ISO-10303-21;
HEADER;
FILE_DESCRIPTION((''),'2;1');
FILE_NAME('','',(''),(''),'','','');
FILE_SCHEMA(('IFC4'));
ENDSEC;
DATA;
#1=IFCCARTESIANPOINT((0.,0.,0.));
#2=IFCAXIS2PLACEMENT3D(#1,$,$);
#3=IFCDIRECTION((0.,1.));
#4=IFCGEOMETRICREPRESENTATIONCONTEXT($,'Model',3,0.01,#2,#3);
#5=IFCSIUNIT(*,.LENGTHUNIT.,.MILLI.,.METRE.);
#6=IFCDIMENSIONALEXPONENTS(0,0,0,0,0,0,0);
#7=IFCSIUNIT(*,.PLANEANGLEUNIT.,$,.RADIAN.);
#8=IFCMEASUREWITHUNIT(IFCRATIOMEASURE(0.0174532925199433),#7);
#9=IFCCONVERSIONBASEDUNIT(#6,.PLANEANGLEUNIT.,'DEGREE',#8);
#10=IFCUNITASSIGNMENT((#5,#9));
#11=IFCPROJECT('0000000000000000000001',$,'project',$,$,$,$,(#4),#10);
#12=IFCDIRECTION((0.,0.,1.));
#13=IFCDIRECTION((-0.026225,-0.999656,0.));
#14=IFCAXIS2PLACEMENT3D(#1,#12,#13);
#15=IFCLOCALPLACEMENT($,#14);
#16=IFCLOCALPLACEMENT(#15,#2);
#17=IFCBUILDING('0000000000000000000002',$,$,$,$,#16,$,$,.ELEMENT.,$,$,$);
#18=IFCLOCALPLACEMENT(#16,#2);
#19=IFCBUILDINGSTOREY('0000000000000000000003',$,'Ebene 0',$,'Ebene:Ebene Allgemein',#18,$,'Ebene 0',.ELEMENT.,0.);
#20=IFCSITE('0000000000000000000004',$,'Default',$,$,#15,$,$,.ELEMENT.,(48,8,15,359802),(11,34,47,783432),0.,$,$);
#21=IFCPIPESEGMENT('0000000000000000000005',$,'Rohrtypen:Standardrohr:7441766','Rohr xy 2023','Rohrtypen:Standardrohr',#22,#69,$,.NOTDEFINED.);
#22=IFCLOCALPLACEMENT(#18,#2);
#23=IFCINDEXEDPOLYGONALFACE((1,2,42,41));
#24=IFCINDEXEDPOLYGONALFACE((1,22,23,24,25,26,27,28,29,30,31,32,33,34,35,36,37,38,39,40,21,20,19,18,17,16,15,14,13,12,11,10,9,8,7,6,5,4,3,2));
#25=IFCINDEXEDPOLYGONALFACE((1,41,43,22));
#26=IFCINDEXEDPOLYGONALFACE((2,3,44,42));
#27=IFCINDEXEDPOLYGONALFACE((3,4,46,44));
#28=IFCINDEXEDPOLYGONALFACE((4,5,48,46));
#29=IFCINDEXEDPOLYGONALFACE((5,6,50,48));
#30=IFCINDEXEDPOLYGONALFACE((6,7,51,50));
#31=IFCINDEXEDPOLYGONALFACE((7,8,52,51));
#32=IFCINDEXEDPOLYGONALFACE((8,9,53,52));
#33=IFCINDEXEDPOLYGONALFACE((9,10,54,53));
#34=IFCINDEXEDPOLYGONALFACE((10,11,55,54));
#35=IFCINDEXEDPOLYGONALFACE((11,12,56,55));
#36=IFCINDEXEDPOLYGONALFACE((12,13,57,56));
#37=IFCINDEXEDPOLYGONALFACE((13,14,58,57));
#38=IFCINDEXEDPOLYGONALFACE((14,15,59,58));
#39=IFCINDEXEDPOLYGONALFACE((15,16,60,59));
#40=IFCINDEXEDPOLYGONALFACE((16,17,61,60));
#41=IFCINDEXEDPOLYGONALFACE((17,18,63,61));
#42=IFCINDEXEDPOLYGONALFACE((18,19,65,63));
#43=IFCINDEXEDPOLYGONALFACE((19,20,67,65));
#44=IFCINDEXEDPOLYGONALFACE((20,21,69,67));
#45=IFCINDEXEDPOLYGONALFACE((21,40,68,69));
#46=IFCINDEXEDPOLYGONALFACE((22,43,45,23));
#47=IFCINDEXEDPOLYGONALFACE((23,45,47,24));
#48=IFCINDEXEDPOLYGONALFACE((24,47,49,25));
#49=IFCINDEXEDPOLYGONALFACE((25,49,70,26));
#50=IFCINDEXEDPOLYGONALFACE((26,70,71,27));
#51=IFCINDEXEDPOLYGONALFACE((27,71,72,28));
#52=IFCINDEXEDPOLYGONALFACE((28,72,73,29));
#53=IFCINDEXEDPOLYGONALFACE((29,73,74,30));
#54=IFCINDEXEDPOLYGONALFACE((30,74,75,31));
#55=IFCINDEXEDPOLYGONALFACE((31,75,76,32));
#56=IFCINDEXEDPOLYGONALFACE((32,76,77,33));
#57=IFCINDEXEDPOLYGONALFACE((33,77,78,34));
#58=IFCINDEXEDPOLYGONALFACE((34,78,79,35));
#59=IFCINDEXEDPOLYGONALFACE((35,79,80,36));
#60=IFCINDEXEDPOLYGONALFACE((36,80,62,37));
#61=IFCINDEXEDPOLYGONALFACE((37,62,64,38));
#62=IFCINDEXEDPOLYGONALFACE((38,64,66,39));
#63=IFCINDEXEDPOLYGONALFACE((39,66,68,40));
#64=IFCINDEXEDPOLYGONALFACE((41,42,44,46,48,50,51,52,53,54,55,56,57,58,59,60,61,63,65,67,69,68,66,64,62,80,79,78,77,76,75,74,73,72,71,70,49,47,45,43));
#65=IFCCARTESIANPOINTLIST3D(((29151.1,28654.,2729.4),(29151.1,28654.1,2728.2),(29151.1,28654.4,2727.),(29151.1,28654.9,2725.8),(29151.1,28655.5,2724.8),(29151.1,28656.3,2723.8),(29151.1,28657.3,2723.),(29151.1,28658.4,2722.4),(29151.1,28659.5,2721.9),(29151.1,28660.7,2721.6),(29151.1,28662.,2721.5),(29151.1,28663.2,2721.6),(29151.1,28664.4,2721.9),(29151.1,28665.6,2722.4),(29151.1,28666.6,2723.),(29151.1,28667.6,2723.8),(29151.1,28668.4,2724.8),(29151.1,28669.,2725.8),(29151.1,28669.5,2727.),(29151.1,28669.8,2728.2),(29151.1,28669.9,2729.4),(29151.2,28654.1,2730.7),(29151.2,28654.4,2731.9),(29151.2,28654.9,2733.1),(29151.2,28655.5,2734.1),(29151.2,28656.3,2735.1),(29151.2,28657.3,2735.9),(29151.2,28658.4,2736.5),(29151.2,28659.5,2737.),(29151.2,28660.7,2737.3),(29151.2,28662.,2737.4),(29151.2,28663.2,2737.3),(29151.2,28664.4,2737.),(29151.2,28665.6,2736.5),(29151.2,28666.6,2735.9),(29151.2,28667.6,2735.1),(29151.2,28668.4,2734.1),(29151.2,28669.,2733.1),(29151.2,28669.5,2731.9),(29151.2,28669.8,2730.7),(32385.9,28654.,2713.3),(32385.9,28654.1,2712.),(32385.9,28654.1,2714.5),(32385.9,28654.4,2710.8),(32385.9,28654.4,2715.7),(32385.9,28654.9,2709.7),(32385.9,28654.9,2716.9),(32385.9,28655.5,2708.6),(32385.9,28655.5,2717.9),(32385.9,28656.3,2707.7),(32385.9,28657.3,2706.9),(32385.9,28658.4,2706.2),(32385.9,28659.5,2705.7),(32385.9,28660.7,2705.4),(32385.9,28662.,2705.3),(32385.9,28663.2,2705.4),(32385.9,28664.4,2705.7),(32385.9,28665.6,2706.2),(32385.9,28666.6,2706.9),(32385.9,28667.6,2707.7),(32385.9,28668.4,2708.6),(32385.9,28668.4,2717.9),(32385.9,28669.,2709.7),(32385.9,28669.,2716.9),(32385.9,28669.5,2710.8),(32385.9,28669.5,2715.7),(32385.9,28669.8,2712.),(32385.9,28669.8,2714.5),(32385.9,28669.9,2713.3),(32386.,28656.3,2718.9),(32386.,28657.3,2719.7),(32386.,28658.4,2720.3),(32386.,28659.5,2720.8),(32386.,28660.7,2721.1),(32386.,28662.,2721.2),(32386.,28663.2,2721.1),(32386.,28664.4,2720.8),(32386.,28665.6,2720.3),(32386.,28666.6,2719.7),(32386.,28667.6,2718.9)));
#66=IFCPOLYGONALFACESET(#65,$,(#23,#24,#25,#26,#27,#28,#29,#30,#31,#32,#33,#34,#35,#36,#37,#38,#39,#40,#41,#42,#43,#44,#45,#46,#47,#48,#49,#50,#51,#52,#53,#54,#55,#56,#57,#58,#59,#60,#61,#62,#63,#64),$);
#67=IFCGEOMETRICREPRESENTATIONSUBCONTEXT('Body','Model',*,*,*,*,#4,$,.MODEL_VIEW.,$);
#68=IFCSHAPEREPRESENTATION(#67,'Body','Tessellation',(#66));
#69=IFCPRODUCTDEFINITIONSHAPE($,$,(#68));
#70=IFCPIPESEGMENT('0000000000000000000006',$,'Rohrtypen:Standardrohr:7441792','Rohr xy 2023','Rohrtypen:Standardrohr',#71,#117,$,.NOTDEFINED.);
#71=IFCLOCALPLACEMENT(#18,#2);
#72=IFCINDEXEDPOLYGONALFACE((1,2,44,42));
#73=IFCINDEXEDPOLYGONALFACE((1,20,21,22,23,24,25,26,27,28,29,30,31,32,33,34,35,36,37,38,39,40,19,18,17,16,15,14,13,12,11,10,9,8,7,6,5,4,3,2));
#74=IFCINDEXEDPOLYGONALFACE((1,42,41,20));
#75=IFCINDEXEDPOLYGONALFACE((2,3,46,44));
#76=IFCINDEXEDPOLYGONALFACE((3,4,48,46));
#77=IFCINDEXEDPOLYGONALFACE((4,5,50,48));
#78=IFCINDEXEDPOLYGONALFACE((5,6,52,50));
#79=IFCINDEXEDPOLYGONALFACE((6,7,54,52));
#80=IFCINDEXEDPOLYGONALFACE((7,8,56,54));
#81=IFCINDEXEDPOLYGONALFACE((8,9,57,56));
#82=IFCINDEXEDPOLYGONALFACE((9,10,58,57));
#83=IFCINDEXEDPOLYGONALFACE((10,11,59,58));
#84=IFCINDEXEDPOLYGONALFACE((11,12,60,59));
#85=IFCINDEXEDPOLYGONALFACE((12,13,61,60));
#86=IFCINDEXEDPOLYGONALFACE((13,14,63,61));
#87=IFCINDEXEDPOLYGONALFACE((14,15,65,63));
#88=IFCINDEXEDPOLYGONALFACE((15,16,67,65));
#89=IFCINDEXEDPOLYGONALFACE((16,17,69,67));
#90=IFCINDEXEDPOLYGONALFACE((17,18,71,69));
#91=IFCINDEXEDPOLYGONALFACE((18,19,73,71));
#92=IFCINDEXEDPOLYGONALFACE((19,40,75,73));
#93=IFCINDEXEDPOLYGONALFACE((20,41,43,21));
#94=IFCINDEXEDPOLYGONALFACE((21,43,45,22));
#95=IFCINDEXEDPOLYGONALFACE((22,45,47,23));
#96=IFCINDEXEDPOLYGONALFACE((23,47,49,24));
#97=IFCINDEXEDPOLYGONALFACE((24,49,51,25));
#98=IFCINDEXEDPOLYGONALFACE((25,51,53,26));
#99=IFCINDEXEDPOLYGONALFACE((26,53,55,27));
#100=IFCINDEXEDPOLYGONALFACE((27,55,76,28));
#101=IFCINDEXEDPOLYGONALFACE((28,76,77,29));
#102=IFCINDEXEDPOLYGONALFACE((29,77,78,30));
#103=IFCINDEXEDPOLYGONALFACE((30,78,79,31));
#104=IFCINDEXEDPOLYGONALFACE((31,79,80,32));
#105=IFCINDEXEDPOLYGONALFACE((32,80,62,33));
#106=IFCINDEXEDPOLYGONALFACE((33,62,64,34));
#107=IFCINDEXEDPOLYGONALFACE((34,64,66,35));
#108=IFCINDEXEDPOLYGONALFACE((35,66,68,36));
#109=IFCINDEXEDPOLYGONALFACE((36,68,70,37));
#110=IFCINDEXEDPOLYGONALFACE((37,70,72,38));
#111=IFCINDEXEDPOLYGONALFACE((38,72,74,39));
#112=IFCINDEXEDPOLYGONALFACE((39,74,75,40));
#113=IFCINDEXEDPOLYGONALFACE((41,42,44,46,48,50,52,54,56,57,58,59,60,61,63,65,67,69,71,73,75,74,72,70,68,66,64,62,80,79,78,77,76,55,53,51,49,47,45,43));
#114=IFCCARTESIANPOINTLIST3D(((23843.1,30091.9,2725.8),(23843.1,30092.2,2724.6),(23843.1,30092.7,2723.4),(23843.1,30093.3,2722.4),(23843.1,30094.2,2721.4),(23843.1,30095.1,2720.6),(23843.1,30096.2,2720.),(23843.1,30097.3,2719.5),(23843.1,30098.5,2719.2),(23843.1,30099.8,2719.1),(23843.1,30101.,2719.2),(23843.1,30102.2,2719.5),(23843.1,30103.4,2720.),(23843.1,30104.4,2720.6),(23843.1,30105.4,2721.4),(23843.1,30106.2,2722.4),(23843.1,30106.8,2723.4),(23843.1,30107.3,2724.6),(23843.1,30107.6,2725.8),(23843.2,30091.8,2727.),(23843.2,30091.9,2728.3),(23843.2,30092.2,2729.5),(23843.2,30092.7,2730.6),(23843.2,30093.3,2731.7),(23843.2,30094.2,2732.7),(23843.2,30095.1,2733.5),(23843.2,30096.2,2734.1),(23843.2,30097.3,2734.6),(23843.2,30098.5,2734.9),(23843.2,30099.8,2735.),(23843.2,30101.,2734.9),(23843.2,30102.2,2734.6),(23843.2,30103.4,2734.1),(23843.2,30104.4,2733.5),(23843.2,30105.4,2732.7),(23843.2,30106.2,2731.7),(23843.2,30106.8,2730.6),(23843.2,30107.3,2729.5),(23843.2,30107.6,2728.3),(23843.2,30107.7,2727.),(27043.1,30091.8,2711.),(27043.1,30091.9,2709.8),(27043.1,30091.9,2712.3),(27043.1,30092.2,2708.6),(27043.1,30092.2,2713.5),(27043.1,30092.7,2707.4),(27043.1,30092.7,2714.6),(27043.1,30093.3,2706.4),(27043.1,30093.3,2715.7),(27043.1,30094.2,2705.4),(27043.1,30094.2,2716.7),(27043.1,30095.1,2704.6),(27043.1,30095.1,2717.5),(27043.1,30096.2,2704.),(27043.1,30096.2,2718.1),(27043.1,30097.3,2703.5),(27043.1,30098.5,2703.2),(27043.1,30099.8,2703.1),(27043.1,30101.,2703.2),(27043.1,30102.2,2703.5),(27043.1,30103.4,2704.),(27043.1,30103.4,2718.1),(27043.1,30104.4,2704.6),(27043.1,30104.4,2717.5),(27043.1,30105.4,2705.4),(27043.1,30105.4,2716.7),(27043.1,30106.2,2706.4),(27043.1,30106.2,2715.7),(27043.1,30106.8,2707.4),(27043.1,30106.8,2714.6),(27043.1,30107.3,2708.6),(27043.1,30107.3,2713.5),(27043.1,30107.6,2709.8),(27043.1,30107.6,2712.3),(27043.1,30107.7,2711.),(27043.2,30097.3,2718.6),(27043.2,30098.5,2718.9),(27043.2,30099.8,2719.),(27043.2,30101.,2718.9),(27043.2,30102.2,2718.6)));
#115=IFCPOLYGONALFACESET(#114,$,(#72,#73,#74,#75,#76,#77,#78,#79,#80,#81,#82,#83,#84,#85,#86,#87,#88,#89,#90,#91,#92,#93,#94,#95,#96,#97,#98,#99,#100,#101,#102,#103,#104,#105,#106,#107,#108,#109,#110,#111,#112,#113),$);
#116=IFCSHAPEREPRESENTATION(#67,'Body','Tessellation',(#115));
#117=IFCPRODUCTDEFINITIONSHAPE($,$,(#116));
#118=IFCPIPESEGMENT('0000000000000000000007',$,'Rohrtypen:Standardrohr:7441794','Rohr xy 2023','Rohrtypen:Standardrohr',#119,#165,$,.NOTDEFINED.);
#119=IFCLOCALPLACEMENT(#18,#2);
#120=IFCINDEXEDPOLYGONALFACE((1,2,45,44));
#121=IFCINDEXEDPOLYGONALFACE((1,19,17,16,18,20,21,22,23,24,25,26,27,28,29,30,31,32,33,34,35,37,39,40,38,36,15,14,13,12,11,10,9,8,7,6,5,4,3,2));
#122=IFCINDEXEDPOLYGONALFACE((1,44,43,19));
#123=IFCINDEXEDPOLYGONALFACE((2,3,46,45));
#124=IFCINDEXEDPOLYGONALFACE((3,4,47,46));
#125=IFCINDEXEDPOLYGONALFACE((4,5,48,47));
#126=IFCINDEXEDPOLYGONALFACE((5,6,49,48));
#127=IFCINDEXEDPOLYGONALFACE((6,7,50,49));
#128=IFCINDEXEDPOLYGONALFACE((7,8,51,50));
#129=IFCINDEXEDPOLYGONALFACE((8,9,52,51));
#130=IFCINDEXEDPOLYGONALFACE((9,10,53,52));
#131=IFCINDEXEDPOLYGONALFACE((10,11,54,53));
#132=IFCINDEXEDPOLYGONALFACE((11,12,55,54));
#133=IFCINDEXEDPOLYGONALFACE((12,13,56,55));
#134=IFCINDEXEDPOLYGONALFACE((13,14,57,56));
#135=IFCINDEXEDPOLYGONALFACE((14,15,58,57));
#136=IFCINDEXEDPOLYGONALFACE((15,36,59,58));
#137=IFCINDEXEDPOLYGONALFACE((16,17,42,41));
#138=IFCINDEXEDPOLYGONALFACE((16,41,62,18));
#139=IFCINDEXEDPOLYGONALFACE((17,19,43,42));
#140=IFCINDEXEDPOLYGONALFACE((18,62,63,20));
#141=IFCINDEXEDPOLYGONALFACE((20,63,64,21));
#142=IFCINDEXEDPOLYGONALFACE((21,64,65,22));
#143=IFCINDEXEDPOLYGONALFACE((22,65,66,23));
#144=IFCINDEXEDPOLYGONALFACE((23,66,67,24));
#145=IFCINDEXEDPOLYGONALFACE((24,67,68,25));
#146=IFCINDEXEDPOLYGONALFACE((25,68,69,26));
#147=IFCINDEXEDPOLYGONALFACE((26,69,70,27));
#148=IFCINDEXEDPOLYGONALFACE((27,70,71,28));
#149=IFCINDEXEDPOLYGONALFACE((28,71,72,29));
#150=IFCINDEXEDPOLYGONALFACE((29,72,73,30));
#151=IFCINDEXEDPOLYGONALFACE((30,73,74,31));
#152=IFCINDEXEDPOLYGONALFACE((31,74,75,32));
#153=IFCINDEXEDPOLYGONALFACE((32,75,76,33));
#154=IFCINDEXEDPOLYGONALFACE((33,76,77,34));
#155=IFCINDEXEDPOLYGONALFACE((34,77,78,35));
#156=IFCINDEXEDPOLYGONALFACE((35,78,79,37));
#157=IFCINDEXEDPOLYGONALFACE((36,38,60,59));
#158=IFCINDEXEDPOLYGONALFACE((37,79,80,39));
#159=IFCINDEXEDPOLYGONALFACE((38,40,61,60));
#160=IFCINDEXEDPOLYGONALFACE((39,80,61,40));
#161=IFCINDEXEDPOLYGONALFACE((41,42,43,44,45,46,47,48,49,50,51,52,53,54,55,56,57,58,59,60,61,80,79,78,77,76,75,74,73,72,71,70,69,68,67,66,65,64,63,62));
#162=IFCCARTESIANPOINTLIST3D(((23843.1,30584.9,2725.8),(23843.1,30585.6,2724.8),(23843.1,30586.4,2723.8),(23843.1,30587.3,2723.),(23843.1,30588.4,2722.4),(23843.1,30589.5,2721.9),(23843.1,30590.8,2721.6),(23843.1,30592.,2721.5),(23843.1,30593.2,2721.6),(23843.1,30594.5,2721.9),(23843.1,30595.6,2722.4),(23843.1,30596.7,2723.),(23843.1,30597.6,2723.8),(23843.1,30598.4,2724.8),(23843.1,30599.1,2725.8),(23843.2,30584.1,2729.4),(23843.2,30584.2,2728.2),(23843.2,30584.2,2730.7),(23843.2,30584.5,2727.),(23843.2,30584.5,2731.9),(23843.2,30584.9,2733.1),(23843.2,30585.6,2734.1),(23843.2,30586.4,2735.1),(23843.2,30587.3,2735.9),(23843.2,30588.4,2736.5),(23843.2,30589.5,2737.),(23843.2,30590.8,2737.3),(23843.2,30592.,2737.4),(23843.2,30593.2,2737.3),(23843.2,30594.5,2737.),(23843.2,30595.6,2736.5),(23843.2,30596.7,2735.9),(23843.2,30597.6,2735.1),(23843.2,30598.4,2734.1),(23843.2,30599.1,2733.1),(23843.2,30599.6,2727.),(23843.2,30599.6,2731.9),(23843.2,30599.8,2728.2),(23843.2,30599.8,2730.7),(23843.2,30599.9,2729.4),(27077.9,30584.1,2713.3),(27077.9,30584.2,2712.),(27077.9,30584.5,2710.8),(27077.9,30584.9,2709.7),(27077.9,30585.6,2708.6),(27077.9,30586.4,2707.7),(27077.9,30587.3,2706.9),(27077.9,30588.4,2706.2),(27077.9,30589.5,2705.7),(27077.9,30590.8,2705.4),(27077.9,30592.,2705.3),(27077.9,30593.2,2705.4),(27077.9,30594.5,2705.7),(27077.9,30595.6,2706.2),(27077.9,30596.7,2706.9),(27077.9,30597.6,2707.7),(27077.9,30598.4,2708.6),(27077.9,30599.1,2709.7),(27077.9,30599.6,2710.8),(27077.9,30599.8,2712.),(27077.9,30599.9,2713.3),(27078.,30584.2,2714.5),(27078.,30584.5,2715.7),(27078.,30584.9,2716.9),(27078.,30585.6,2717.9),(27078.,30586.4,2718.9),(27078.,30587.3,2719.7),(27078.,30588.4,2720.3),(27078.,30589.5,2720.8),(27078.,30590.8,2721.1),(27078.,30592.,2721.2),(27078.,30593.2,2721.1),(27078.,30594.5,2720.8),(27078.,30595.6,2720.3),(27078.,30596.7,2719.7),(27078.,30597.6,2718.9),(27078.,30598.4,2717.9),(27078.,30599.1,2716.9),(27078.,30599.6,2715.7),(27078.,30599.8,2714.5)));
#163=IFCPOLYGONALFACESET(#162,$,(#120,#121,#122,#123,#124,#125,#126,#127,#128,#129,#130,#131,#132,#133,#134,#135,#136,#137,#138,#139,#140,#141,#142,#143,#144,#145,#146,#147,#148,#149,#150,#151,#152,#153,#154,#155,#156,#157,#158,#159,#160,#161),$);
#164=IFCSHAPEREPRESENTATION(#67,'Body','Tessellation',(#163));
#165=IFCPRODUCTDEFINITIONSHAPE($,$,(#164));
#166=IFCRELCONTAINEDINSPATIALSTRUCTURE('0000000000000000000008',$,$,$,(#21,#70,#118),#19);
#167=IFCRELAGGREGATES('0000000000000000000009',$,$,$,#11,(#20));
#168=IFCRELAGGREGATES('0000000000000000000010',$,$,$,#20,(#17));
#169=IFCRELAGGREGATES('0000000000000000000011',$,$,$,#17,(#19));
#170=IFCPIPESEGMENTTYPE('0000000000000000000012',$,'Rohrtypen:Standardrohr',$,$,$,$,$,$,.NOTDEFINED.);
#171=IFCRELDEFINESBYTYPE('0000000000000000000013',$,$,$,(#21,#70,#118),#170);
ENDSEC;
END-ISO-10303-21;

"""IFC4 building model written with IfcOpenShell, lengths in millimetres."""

from ifc_helpers import new_model, entity, si_unit, converted_unit, direction, frame, origin, place, context, subcontext, project, spatial, indexed_curve, outline, extrude, type_object, element, save


model = new_model("IFC4")

# Units and contexts
model_context = context("Model", 3, precision=0.01, world=origin(), true_north=direction((0.0, 1.0)))
body_context = subcontext(model_context, "Body", "Model", "MODEL_VIEW")
ifc_project = project(units=[si_unit("LENGTHUNIT", "METRE", prefix="MILLI"), converted_unit("PLANEANGLEUNIT", "DEGREE", entity("IfcRatioMeasure", 0.0174532925199433), si_unit("PLANEANGLEUNIT", "RADIAN"), dimensions=[0, 0, 0, 0, 0, 0, 0])], contexts=[model_context])

# Site, building, storey
site_placement = place(None, frame((0.0, 0.0, 0.0), z_axis=(0.0, 0.0, 1.0), x_axis=(-0.026225, -0.999656, 0.0)))
site = spatial("IfcSite", under=ifc_project, at=site_placement, Name="Default", CompositionType="ELEMENT", RefLatitude=(48, 8, 15, 359802), RefLongitude=(11, 34, 47, 783432), RefElevation=0.0)
building_placement = place(site_placement, origin())
building = spatial("IfcBuilding", under=site, at=building_placement, CompositionType="ELEMENT")
storey_placement = place(building_placement, origin())
storey = spatial("IfcBuildingStorey", under=building, at=storey_placement, Name="Ebene 0", ObjectType="Ebene:Ebene Allgemein", LongName="Ebene 0", CompositionType="ELEMENT", Elevation=0.0)

# Pipe segments
pipe_segment_type = type_object("IfcPipeSegmentType", Name="Rohrtypen:Standardrohr", PredefinedType="NOTDEFINED")
pipe_segment_1_placement = place(storey_placement, origin())
element("IfcPipeSegment", 1, at=pipe_segment_1_placement, inside=storey, type_object=pipe_segment_type, Name="Rohrtypen:Standardrohr:7441766", Description="Rohr xy 2023", ObjectType="Rohrtypen:Standardrohr", PredefinedType="NOTDEFINED", context=body_context, shape_type="SweptSolid", body=[
    extrude(outline(indexed_curve([(7.9, 0.0), (7.8, 1.2), (7.6, 2.5), (7.1, 3.6), (6.4, 4.7), (5.6, 5.6), (4.7, 6.4), (3.6, 7.1), (2.5, 7.6), (1.2, 7.8), (0.0, 7.9), (-1.2, 7.8), (-2.5, 7.6), (-3.6, 7.1), (-4.7, 6.4), (-5.6, 5.6), (-6.4, 4.7), (-7.1, 3.6), (-7.6, 2.5), (-7.8, 1.2), (-7.9, 0.0), (-7.8, -1.2), (-7.6, -2.5), (-7.1, -3.6), (-6.4, -4.7), (-5.6, -5.6), (-4.7, -6.4), (-3.6, -7.1), (-2.5, -7.6), (-1.2, -7.8), (0.0, -7.9), (1.2, -7.8), (2.5, -7.6), (3.6, -7.1), (4.7, -6.4), (5.6, -5.6), (6.4, -4.7), (7.1, -3.6), (7.6, -2.5), (7.8, -1.2), (7.9, 0.0)], self_intersect=False)), frame((32385.9, 28662.0, 2713.3), z_axis=(-0.999988, 0.0, 0.005), x_axis=(0.0, 1.0, 0.0)), (0.0, 0.0, 1.0), 3234.8),
])
pipe_segment_2_placement = place(storey_placement, origin())
element("IfcPipeSegment", 2, at=pipe_segment_2_placement, inside=storey, type_object=pipe_segment_type, Name="Rohrtypen:Standardrohr:7441792", Description="Rohr xy 2023", ObjectType="Rohrtypen:Standardrohr", PredefinedType="NOTDEFINED", context=body_context, shape_type="SweptSolid", body=[
    extrude(outline(indexed_curve([(7.9, 0.0), (7.8, 1.2), (7.6, 2.5), (7.1, 3.6), (6.4, 4.7), (5.6, 5.6), (4.7, 6.4), (3.6, 7.1), (2.5, 7.6), (1.2, 7.8), (0.0, 7.9), (-1.2, 7.8), (-2.5, 7.6), (-3.6, 7.1), (-4.7, 6.4), (-5.6, 5.6), (-6.4, 4.7), (-7.1, 3.6), (-7.6, 2.5), (-7.8, 1.2), (-7.9, 0.0), (-7.8, -1.2), (-7.6, -2.5), (-7.1, -3.6), (-6.4, -4.7), (-5.6, -5.6), (-4.7, -6.4), (-3.6, -7.1), (-2.5, -7.6), (-1.2, -7.8), (0.0, -7.9), (1.2, -7.8), (2.5, -7.6), (3.6, -7.1), (4.7, -6.4), (5.6, -5.6), (6.4, -4.7), (7.1, -3.6), (7.6, -2.5), (7.8, -1.2), (7.9, 0.0)], self_intersect=False)), frame((27043.1, 30099.8, 2711.0), z_axis=(-0.999988, 0.0, 0.005), x_axis=(0.0, 1.0, 0.0)), (0.0, 0.0, 1.0), 3200.0),
])
pipe_segment_3_placement = place(storey_placement, origin())
element("IfcPipeSegment", 3, at=pipe_segment_3_placement, inside=storey, type_object=pipe_segment_type, Name="Rohrtypen:Standardrohr:7441794", Description="Rohr xy 2023", ObjectType="Rohrtypen:Standardrohr", PredefinedType="NOTDEFINED", context=body_context, shape_type="SweptSolid", body=[
    extrude(outline(indexed_curve([(7.9, 0.0), (7.8, 1.2), (7.6, 2.5), (7.1, 3.6), (6.4, 4.7), (5.6, 5.6), (4.7, 6.4), (3.6, 7.1), (2.5, 7.6), (1.2, 7.8), (0.0, 7.9), (-1.2, 7.8), (-2.5, 7.6), (-3.6, 7.1), (-4.7, 6.4), (-5.6, 5.6), (-6.4, 4.7), (-7.1, 3.6), (-7.6, 2.5), (-7.8, 1.2), (-7.9, 0.0), (-7.8, -1.2), (-7.6, -2.5), (-7.1, -3.6), (-6.4, -4.7), (-5.6, -5.6), (-4.7, -6.4), (-3.6, -7.1), (-2.5, -7.6), (-1.2, -7.8), (0.0, -7.9), (1.2, -7.8), (2.5, -7.6), (3.6, -7.1), (4.7, -6.4), (5.6, -5.6), (6.4, -4.7), (7.1, -3.6), (7.6, -2.5), (7.8, -1.2), (7.9, 0.0)], self_intersect=False)), frame((27077.9, 30592.0, 2713.3), z_axis=(-0.999988, 0.0, 0.005), x_axis=(0.0, 1.0, 0.0)), (0.0, 0.0, 1.0), 3234.8),
])

save(model, "model.ifc")
